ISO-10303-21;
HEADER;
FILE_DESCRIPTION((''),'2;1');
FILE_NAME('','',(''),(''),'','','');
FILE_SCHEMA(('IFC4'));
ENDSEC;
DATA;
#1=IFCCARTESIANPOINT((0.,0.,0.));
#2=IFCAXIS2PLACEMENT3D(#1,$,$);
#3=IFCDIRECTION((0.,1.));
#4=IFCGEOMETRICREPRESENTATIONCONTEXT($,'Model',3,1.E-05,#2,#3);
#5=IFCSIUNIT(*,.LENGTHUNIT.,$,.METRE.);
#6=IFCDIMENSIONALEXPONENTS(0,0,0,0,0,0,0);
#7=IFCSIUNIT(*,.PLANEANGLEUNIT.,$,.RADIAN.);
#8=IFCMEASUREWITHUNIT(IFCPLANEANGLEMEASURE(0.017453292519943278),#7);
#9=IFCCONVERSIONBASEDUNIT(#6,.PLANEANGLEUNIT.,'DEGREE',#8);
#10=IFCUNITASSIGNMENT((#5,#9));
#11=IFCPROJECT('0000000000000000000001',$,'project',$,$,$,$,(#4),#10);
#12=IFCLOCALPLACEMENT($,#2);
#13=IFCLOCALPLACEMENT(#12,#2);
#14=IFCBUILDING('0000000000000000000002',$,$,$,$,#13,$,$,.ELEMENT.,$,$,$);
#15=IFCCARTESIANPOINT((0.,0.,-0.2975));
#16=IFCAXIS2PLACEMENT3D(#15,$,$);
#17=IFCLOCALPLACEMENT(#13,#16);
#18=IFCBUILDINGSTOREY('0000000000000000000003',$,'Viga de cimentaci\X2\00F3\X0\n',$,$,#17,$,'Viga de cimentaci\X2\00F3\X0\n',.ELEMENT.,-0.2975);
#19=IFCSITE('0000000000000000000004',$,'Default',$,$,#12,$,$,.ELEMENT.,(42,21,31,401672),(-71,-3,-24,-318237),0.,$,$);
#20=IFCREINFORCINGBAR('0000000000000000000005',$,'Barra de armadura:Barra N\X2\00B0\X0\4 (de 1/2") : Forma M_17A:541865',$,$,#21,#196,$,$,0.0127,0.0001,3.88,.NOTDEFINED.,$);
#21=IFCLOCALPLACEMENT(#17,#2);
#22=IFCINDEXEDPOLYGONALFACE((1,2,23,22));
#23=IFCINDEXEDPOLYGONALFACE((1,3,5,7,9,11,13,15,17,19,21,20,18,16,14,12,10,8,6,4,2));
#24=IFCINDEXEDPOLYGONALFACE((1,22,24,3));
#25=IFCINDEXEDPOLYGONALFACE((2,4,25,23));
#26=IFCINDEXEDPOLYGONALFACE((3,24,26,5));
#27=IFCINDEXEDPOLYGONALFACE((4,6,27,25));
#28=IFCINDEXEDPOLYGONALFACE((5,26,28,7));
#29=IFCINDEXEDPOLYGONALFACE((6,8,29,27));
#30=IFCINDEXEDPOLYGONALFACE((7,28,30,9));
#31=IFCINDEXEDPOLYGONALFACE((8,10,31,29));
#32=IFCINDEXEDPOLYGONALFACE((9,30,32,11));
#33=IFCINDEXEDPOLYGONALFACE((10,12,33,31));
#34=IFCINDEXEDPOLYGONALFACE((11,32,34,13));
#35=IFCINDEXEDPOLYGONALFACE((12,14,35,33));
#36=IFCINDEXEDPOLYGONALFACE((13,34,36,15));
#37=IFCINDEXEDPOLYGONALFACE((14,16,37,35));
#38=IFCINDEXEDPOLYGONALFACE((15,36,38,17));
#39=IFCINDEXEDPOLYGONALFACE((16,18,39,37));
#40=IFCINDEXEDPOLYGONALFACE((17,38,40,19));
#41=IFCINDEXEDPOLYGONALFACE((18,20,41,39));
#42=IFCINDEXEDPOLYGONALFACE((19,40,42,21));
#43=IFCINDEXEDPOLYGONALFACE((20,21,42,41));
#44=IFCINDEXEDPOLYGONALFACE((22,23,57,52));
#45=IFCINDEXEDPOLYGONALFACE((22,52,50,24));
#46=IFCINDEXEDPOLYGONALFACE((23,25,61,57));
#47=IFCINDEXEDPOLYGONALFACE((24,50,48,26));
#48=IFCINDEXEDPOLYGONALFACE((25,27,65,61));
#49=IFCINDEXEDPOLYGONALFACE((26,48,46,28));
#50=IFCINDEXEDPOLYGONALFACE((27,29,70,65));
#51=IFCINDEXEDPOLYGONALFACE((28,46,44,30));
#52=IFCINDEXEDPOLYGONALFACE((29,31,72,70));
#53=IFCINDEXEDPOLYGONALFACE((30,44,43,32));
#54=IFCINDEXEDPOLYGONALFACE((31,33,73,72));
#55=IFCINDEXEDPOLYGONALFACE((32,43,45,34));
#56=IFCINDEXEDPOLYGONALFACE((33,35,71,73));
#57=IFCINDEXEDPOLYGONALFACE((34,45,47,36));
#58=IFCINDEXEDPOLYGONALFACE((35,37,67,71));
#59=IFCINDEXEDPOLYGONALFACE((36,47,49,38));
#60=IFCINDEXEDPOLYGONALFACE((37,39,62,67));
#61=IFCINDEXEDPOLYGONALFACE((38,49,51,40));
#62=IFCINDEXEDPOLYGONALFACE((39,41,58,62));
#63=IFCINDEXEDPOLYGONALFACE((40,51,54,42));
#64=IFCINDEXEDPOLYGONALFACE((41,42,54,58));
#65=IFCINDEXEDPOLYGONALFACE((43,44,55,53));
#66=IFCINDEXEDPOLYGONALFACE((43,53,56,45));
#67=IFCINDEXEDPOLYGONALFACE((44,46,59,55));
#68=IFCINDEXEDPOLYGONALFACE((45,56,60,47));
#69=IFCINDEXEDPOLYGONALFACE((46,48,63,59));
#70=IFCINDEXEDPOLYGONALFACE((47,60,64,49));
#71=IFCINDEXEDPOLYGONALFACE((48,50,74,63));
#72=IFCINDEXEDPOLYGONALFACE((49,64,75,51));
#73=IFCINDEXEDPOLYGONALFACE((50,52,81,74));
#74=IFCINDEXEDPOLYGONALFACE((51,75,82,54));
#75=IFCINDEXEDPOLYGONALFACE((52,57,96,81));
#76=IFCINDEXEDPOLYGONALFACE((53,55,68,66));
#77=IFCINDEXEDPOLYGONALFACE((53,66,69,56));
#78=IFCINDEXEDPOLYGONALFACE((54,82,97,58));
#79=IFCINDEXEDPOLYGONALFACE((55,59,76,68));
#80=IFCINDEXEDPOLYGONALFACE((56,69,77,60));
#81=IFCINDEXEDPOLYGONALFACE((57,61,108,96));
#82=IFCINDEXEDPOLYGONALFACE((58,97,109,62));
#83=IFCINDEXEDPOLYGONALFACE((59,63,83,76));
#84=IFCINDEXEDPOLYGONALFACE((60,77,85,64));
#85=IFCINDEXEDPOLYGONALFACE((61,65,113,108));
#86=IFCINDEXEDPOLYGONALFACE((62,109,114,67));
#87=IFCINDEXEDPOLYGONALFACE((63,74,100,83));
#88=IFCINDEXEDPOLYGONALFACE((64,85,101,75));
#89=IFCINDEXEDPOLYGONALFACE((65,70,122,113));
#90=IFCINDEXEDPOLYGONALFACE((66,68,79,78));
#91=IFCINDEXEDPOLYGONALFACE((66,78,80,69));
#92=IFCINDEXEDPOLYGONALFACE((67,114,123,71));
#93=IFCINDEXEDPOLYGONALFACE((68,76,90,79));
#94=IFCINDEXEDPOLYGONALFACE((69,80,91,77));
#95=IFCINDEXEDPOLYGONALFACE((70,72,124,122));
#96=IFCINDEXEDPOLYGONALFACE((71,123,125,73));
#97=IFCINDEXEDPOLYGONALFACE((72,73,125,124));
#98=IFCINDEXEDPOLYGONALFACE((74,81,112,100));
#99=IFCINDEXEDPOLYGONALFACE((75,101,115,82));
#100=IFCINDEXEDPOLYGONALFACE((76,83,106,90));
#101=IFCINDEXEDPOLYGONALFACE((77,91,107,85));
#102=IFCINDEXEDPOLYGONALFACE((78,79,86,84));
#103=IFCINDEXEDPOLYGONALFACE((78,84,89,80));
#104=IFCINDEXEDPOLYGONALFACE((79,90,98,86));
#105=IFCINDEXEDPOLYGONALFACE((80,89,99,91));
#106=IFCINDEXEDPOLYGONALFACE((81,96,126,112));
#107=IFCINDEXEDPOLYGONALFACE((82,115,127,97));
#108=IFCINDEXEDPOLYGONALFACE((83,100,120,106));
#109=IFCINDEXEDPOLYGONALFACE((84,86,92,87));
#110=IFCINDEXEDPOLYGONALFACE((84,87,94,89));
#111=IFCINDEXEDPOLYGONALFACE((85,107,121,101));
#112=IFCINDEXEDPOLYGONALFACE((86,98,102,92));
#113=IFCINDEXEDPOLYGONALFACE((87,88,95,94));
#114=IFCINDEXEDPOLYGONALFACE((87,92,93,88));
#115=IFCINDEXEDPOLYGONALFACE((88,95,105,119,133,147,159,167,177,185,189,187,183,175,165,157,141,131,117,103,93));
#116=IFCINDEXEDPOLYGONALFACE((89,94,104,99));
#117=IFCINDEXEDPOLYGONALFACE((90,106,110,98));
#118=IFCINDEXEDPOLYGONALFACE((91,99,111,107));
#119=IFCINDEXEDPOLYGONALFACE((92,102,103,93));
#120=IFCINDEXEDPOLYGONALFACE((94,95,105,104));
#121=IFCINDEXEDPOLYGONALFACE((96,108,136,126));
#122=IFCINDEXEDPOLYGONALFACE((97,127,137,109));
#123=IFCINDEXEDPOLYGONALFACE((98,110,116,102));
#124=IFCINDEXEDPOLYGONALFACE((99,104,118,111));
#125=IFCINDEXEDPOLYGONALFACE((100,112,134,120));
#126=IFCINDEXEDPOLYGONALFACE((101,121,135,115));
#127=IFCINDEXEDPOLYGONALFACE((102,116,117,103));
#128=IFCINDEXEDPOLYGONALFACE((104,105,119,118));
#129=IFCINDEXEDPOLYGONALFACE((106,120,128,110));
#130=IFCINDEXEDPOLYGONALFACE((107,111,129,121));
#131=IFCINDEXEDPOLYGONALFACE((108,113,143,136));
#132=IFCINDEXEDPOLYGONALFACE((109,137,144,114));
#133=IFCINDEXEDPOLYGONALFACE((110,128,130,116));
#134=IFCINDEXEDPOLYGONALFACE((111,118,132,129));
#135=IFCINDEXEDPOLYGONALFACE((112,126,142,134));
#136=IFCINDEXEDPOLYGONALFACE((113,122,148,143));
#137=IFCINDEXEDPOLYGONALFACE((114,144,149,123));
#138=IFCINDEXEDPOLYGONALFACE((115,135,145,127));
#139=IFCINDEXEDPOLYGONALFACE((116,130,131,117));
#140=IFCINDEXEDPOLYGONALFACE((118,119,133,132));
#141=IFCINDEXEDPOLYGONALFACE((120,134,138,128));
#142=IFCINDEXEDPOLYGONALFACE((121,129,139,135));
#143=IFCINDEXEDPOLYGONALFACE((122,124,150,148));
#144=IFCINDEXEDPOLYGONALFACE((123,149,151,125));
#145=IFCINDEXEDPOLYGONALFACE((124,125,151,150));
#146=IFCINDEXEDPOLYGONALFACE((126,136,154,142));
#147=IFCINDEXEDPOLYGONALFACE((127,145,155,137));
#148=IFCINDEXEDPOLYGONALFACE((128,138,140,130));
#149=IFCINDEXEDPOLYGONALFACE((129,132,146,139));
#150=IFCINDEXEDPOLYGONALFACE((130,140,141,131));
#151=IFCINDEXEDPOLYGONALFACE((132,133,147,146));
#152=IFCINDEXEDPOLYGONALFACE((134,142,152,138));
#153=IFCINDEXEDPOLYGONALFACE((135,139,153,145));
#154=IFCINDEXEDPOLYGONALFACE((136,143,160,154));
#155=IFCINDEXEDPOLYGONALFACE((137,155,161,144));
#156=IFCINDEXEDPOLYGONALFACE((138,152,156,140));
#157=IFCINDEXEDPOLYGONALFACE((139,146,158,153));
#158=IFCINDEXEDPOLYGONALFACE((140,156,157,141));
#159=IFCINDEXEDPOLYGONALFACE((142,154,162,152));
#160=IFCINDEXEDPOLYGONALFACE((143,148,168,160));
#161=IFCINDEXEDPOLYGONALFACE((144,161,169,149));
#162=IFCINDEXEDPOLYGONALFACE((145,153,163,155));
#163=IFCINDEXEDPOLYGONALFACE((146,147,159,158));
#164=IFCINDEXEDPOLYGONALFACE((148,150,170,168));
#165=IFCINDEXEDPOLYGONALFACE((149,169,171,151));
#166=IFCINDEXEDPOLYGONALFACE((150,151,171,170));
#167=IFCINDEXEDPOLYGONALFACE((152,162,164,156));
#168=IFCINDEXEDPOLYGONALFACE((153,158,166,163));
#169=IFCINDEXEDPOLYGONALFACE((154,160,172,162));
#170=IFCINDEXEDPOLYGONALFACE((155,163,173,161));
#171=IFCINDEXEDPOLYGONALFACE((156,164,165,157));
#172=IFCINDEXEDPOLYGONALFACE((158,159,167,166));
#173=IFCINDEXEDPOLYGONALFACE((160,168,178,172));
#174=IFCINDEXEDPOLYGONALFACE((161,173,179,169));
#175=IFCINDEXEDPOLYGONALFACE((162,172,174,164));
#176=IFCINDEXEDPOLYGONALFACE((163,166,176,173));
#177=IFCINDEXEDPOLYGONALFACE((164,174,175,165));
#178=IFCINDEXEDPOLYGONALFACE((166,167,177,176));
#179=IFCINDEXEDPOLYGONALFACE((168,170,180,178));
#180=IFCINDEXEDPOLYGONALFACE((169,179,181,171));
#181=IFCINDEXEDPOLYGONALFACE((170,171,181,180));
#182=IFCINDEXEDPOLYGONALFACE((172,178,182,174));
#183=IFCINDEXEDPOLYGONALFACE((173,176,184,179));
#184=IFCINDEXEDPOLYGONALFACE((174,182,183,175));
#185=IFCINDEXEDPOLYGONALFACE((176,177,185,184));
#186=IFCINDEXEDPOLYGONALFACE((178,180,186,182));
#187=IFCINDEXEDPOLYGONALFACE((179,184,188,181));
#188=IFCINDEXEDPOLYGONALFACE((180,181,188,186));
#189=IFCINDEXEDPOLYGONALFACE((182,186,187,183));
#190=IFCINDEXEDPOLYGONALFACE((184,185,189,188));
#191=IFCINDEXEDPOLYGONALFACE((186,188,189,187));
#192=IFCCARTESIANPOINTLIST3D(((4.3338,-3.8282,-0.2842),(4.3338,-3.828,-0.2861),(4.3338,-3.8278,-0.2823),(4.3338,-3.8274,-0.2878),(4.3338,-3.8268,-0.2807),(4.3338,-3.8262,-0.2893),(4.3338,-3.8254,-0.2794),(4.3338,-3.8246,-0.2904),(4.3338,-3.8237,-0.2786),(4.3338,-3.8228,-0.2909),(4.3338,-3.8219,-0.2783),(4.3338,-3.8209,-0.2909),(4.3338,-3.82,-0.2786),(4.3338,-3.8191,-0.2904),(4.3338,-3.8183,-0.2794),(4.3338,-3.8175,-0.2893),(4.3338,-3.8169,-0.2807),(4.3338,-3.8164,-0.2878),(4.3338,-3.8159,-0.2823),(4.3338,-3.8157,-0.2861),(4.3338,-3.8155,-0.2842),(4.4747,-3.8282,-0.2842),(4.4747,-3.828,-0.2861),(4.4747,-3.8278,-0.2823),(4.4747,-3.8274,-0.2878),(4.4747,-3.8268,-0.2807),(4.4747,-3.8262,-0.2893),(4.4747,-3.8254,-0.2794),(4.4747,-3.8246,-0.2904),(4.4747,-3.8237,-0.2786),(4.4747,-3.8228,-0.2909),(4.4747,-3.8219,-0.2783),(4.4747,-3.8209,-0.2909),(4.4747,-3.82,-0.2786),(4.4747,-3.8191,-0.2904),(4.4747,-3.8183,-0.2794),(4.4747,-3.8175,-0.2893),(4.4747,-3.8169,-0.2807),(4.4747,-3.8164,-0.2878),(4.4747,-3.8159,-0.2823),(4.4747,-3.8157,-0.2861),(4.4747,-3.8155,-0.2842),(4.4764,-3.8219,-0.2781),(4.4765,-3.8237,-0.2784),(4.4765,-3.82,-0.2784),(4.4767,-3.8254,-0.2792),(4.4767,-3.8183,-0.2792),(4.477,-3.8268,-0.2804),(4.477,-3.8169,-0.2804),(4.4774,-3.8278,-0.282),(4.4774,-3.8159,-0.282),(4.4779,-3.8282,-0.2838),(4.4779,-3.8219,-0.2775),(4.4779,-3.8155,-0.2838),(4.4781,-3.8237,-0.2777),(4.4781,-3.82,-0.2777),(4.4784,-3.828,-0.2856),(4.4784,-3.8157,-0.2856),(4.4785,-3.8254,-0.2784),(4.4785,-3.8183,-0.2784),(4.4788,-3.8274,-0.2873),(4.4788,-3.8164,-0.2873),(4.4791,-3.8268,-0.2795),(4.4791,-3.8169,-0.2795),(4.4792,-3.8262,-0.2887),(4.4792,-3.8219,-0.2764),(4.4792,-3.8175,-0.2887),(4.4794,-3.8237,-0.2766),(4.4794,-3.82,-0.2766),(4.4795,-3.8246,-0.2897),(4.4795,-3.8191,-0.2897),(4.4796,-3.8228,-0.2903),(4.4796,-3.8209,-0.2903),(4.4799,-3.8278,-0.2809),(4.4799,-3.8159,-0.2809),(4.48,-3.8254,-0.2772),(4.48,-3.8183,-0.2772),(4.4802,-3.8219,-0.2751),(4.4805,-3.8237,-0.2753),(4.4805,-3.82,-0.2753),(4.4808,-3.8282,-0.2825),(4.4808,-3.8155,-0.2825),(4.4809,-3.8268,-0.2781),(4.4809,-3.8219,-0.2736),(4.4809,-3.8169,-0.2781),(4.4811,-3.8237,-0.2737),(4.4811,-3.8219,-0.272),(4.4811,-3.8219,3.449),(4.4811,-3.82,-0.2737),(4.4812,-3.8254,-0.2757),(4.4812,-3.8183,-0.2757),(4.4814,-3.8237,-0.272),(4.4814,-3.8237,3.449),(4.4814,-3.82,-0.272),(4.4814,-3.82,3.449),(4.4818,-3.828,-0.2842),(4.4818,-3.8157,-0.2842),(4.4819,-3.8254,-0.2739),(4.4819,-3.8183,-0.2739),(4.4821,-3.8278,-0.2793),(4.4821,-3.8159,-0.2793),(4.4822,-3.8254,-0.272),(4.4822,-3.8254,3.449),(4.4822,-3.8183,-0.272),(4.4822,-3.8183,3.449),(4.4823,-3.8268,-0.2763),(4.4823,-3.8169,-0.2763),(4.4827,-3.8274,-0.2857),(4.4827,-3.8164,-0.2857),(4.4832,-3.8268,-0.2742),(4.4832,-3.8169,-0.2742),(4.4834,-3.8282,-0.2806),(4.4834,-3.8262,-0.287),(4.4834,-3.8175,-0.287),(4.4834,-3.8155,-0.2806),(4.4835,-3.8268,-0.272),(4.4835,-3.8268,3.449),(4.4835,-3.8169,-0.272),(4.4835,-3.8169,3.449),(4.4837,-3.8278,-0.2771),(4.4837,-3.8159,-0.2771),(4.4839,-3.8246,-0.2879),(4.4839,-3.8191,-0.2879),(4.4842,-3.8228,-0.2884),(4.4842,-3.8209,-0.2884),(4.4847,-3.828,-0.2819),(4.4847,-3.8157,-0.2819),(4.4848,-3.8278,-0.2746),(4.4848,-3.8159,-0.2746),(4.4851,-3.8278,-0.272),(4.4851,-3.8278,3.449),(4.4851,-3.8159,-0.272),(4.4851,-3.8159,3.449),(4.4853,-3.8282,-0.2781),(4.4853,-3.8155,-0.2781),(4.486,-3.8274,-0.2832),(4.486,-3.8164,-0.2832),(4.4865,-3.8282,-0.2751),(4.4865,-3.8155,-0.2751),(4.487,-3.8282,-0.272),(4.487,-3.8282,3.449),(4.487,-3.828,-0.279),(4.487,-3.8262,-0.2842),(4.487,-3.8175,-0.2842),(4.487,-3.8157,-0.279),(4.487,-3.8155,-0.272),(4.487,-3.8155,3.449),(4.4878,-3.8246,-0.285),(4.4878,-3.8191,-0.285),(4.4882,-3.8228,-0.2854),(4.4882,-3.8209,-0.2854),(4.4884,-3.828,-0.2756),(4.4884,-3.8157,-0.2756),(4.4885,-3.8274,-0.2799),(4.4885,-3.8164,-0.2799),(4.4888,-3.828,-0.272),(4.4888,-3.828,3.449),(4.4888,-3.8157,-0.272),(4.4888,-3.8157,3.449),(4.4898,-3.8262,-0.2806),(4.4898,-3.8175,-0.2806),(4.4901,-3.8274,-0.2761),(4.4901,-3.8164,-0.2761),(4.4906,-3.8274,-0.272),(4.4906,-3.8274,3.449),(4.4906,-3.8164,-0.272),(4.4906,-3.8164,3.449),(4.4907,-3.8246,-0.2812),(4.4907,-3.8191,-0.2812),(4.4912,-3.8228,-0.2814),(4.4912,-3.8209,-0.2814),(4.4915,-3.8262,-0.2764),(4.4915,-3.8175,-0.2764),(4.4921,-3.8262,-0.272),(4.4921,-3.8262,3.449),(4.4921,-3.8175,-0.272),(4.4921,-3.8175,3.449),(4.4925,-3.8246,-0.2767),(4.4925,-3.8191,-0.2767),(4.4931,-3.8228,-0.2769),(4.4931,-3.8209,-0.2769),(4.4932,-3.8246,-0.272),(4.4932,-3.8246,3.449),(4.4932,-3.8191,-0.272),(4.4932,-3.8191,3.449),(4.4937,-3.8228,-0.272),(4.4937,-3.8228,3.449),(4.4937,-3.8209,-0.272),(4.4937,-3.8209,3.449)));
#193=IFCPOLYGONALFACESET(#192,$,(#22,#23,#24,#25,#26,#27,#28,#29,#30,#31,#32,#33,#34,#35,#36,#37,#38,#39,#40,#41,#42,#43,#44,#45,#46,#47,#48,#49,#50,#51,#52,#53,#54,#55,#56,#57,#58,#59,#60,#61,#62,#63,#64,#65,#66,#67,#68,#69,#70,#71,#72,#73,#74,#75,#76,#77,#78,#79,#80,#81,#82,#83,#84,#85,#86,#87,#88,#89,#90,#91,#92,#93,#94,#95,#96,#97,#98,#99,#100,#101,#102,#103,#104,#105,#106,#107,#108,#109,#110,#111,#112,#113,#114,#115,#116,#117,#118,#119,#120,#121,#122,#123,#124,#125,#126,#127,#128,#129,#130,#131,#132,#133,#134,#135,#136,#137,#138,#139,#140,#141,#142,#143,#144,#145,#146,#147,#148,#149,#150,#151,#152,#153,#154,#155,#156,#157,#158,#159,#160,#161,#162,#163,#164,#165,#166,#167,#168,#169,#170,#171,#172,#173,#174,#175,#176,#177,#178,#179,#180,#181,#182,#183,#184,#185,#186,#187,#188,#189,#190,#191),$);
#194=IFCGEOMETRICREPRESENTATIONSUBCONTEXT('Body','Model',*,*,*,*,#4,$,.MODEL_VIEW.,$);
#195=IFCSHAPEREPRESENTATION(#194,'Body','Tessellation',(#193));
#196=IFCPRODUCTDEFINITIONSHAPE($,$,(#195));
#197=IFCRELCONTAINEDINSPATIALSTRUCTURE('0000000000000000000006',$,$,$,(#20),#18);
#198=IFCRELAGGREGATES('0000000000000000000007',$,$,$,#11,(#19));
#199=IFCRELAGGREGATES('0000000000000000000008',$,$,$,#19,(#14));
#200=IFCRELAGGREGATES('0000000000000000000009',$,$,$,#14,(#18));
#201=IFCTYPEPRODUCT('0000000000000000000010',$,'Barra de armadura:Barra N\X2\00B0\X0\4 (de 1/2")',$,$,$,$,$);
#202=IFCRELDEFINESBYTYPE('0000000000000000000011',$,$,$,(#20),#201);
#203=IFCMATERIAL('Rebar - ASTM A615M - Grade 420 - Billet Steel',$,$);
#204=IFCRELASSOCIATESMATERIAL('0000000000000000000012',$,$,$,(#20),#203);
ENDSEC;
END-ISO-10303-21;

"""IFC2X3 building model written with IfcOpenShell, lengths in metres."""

from ifc_helpers import new_model, entity, si_unit, converted_unit, direction, frame, origin, place, context, subcontext, project, spatial, material, type_object, element, save


model = new_model("IFC2X3")

# Units and contexts
model_context = context("Model", 3, precision=1e-05, world=origin(), true_north=direction((0.0, 1.0)))
body_context = subcontext(model_context, "Body", "Model", "MODEL_VIEW")
ifc_project = project(units=[si_unit("LENGTHUNIT", "METRE"), converted_unit("PLANEANGLEUNIT", "DEGREE", entity("IfcPlaneAngleMeasure", 0.017453292519943278), si_unit("PLANEANGLEUNIT", "RADIAN"), dimensions=[0, 0, 0, 0, 0, 0, 0])], contexts=[model_context])

# Site, building, storey
site_placement = place(None, origin())
site = spatial("IfcSite", under=ifc_project, at=site_placement, Name="Default", CompositionType="ELEMENT", RefLatitude=(42, 21, 31, 401672), RefLongitude=(-71, -3, -24, -318237), RefElevation=0.0)
building_placement = place(site_placement, origin())
building = spatial("IfcBuilding", under=site, at=building_placement, CompositionType="ELEMENT")
storey_placement = place(building_placement, frame((0.0, 0.0, -0.2975)))
storey = spatial("IfcBuildingStorey", under=building, at=storey_placement, Name="Viga de cimentación", LongName="Viga de cimentación", CompositionType="ELEMENT", Elevation=-0.2975)

# Reinforcing bar
ifc_material_1 = material(Name="Rebar - ASTM A615M - Grade 420 - Billet Steel")
type_product_1 = type_object("IfcTypeProduct", Name="Barra de armadura:Barra N°4 (de 1/2\")")
reinforcing_bar_1_placement = place(storey_placement, origin())
element("IfcReinforcingBar", 1, at=reinforcing_bar_1_placement, inside=storey, type_object=type_product_1, material=ifc_material_1, Name="Barra de armadura:Barra N°4 (de 1/2\") : Forma M_17A:541865", BarLength=3.88, BarRole="NOTDEFINED", CrossSectionArea=0.0001, NominalDiameter=0.0127, context=body_context, shape_type="AdvancedSweptSolid", body=[
    entity("IfcSweptDiskSolid", entity("IfcCompositeCurve", [entity("IfcCompositeCurveSegment", "CONTINUOUS", True, entity("IfcPolyline", [entity("IfcCartesianPoint", [4.4874, -3.8219, 3.449]), entity("IfcCartesianPoint", [4.4874, -3.8219, -0.272])])), entity("IfcCompositeCurveSegment", "CONTINUOUS", True, entity("IfcTrimmedCurve", entity("IfcCircle", entity("IfcAxis2Placement3D", entity("IfcCartesianPoint", [4.4747, -3.8219, -0.272]), entity("IfcDirection", [0.0, 1.0, 0.0]), entity("IfcDirection", [0.0, 0.0, -1.0])), 0.0127), [entity("IfcParameterValue", 270.0)], [entity("IfcParameterValue", 360.0)], True, "PARAMETER")), entity("IfcCompositeCurveSegment", "CONTINUOUS", True, entity("IfcPolyline", [entity("IfcCartesianPoint", [4.4747, -3.8219, -0.2847]), entity("IfcCartesianPoint", [4.3338, -3.8219, -0.2847])]))], False), 0.0063, None, 0.0, 92.0),
])

save(model, "model.ifc")
